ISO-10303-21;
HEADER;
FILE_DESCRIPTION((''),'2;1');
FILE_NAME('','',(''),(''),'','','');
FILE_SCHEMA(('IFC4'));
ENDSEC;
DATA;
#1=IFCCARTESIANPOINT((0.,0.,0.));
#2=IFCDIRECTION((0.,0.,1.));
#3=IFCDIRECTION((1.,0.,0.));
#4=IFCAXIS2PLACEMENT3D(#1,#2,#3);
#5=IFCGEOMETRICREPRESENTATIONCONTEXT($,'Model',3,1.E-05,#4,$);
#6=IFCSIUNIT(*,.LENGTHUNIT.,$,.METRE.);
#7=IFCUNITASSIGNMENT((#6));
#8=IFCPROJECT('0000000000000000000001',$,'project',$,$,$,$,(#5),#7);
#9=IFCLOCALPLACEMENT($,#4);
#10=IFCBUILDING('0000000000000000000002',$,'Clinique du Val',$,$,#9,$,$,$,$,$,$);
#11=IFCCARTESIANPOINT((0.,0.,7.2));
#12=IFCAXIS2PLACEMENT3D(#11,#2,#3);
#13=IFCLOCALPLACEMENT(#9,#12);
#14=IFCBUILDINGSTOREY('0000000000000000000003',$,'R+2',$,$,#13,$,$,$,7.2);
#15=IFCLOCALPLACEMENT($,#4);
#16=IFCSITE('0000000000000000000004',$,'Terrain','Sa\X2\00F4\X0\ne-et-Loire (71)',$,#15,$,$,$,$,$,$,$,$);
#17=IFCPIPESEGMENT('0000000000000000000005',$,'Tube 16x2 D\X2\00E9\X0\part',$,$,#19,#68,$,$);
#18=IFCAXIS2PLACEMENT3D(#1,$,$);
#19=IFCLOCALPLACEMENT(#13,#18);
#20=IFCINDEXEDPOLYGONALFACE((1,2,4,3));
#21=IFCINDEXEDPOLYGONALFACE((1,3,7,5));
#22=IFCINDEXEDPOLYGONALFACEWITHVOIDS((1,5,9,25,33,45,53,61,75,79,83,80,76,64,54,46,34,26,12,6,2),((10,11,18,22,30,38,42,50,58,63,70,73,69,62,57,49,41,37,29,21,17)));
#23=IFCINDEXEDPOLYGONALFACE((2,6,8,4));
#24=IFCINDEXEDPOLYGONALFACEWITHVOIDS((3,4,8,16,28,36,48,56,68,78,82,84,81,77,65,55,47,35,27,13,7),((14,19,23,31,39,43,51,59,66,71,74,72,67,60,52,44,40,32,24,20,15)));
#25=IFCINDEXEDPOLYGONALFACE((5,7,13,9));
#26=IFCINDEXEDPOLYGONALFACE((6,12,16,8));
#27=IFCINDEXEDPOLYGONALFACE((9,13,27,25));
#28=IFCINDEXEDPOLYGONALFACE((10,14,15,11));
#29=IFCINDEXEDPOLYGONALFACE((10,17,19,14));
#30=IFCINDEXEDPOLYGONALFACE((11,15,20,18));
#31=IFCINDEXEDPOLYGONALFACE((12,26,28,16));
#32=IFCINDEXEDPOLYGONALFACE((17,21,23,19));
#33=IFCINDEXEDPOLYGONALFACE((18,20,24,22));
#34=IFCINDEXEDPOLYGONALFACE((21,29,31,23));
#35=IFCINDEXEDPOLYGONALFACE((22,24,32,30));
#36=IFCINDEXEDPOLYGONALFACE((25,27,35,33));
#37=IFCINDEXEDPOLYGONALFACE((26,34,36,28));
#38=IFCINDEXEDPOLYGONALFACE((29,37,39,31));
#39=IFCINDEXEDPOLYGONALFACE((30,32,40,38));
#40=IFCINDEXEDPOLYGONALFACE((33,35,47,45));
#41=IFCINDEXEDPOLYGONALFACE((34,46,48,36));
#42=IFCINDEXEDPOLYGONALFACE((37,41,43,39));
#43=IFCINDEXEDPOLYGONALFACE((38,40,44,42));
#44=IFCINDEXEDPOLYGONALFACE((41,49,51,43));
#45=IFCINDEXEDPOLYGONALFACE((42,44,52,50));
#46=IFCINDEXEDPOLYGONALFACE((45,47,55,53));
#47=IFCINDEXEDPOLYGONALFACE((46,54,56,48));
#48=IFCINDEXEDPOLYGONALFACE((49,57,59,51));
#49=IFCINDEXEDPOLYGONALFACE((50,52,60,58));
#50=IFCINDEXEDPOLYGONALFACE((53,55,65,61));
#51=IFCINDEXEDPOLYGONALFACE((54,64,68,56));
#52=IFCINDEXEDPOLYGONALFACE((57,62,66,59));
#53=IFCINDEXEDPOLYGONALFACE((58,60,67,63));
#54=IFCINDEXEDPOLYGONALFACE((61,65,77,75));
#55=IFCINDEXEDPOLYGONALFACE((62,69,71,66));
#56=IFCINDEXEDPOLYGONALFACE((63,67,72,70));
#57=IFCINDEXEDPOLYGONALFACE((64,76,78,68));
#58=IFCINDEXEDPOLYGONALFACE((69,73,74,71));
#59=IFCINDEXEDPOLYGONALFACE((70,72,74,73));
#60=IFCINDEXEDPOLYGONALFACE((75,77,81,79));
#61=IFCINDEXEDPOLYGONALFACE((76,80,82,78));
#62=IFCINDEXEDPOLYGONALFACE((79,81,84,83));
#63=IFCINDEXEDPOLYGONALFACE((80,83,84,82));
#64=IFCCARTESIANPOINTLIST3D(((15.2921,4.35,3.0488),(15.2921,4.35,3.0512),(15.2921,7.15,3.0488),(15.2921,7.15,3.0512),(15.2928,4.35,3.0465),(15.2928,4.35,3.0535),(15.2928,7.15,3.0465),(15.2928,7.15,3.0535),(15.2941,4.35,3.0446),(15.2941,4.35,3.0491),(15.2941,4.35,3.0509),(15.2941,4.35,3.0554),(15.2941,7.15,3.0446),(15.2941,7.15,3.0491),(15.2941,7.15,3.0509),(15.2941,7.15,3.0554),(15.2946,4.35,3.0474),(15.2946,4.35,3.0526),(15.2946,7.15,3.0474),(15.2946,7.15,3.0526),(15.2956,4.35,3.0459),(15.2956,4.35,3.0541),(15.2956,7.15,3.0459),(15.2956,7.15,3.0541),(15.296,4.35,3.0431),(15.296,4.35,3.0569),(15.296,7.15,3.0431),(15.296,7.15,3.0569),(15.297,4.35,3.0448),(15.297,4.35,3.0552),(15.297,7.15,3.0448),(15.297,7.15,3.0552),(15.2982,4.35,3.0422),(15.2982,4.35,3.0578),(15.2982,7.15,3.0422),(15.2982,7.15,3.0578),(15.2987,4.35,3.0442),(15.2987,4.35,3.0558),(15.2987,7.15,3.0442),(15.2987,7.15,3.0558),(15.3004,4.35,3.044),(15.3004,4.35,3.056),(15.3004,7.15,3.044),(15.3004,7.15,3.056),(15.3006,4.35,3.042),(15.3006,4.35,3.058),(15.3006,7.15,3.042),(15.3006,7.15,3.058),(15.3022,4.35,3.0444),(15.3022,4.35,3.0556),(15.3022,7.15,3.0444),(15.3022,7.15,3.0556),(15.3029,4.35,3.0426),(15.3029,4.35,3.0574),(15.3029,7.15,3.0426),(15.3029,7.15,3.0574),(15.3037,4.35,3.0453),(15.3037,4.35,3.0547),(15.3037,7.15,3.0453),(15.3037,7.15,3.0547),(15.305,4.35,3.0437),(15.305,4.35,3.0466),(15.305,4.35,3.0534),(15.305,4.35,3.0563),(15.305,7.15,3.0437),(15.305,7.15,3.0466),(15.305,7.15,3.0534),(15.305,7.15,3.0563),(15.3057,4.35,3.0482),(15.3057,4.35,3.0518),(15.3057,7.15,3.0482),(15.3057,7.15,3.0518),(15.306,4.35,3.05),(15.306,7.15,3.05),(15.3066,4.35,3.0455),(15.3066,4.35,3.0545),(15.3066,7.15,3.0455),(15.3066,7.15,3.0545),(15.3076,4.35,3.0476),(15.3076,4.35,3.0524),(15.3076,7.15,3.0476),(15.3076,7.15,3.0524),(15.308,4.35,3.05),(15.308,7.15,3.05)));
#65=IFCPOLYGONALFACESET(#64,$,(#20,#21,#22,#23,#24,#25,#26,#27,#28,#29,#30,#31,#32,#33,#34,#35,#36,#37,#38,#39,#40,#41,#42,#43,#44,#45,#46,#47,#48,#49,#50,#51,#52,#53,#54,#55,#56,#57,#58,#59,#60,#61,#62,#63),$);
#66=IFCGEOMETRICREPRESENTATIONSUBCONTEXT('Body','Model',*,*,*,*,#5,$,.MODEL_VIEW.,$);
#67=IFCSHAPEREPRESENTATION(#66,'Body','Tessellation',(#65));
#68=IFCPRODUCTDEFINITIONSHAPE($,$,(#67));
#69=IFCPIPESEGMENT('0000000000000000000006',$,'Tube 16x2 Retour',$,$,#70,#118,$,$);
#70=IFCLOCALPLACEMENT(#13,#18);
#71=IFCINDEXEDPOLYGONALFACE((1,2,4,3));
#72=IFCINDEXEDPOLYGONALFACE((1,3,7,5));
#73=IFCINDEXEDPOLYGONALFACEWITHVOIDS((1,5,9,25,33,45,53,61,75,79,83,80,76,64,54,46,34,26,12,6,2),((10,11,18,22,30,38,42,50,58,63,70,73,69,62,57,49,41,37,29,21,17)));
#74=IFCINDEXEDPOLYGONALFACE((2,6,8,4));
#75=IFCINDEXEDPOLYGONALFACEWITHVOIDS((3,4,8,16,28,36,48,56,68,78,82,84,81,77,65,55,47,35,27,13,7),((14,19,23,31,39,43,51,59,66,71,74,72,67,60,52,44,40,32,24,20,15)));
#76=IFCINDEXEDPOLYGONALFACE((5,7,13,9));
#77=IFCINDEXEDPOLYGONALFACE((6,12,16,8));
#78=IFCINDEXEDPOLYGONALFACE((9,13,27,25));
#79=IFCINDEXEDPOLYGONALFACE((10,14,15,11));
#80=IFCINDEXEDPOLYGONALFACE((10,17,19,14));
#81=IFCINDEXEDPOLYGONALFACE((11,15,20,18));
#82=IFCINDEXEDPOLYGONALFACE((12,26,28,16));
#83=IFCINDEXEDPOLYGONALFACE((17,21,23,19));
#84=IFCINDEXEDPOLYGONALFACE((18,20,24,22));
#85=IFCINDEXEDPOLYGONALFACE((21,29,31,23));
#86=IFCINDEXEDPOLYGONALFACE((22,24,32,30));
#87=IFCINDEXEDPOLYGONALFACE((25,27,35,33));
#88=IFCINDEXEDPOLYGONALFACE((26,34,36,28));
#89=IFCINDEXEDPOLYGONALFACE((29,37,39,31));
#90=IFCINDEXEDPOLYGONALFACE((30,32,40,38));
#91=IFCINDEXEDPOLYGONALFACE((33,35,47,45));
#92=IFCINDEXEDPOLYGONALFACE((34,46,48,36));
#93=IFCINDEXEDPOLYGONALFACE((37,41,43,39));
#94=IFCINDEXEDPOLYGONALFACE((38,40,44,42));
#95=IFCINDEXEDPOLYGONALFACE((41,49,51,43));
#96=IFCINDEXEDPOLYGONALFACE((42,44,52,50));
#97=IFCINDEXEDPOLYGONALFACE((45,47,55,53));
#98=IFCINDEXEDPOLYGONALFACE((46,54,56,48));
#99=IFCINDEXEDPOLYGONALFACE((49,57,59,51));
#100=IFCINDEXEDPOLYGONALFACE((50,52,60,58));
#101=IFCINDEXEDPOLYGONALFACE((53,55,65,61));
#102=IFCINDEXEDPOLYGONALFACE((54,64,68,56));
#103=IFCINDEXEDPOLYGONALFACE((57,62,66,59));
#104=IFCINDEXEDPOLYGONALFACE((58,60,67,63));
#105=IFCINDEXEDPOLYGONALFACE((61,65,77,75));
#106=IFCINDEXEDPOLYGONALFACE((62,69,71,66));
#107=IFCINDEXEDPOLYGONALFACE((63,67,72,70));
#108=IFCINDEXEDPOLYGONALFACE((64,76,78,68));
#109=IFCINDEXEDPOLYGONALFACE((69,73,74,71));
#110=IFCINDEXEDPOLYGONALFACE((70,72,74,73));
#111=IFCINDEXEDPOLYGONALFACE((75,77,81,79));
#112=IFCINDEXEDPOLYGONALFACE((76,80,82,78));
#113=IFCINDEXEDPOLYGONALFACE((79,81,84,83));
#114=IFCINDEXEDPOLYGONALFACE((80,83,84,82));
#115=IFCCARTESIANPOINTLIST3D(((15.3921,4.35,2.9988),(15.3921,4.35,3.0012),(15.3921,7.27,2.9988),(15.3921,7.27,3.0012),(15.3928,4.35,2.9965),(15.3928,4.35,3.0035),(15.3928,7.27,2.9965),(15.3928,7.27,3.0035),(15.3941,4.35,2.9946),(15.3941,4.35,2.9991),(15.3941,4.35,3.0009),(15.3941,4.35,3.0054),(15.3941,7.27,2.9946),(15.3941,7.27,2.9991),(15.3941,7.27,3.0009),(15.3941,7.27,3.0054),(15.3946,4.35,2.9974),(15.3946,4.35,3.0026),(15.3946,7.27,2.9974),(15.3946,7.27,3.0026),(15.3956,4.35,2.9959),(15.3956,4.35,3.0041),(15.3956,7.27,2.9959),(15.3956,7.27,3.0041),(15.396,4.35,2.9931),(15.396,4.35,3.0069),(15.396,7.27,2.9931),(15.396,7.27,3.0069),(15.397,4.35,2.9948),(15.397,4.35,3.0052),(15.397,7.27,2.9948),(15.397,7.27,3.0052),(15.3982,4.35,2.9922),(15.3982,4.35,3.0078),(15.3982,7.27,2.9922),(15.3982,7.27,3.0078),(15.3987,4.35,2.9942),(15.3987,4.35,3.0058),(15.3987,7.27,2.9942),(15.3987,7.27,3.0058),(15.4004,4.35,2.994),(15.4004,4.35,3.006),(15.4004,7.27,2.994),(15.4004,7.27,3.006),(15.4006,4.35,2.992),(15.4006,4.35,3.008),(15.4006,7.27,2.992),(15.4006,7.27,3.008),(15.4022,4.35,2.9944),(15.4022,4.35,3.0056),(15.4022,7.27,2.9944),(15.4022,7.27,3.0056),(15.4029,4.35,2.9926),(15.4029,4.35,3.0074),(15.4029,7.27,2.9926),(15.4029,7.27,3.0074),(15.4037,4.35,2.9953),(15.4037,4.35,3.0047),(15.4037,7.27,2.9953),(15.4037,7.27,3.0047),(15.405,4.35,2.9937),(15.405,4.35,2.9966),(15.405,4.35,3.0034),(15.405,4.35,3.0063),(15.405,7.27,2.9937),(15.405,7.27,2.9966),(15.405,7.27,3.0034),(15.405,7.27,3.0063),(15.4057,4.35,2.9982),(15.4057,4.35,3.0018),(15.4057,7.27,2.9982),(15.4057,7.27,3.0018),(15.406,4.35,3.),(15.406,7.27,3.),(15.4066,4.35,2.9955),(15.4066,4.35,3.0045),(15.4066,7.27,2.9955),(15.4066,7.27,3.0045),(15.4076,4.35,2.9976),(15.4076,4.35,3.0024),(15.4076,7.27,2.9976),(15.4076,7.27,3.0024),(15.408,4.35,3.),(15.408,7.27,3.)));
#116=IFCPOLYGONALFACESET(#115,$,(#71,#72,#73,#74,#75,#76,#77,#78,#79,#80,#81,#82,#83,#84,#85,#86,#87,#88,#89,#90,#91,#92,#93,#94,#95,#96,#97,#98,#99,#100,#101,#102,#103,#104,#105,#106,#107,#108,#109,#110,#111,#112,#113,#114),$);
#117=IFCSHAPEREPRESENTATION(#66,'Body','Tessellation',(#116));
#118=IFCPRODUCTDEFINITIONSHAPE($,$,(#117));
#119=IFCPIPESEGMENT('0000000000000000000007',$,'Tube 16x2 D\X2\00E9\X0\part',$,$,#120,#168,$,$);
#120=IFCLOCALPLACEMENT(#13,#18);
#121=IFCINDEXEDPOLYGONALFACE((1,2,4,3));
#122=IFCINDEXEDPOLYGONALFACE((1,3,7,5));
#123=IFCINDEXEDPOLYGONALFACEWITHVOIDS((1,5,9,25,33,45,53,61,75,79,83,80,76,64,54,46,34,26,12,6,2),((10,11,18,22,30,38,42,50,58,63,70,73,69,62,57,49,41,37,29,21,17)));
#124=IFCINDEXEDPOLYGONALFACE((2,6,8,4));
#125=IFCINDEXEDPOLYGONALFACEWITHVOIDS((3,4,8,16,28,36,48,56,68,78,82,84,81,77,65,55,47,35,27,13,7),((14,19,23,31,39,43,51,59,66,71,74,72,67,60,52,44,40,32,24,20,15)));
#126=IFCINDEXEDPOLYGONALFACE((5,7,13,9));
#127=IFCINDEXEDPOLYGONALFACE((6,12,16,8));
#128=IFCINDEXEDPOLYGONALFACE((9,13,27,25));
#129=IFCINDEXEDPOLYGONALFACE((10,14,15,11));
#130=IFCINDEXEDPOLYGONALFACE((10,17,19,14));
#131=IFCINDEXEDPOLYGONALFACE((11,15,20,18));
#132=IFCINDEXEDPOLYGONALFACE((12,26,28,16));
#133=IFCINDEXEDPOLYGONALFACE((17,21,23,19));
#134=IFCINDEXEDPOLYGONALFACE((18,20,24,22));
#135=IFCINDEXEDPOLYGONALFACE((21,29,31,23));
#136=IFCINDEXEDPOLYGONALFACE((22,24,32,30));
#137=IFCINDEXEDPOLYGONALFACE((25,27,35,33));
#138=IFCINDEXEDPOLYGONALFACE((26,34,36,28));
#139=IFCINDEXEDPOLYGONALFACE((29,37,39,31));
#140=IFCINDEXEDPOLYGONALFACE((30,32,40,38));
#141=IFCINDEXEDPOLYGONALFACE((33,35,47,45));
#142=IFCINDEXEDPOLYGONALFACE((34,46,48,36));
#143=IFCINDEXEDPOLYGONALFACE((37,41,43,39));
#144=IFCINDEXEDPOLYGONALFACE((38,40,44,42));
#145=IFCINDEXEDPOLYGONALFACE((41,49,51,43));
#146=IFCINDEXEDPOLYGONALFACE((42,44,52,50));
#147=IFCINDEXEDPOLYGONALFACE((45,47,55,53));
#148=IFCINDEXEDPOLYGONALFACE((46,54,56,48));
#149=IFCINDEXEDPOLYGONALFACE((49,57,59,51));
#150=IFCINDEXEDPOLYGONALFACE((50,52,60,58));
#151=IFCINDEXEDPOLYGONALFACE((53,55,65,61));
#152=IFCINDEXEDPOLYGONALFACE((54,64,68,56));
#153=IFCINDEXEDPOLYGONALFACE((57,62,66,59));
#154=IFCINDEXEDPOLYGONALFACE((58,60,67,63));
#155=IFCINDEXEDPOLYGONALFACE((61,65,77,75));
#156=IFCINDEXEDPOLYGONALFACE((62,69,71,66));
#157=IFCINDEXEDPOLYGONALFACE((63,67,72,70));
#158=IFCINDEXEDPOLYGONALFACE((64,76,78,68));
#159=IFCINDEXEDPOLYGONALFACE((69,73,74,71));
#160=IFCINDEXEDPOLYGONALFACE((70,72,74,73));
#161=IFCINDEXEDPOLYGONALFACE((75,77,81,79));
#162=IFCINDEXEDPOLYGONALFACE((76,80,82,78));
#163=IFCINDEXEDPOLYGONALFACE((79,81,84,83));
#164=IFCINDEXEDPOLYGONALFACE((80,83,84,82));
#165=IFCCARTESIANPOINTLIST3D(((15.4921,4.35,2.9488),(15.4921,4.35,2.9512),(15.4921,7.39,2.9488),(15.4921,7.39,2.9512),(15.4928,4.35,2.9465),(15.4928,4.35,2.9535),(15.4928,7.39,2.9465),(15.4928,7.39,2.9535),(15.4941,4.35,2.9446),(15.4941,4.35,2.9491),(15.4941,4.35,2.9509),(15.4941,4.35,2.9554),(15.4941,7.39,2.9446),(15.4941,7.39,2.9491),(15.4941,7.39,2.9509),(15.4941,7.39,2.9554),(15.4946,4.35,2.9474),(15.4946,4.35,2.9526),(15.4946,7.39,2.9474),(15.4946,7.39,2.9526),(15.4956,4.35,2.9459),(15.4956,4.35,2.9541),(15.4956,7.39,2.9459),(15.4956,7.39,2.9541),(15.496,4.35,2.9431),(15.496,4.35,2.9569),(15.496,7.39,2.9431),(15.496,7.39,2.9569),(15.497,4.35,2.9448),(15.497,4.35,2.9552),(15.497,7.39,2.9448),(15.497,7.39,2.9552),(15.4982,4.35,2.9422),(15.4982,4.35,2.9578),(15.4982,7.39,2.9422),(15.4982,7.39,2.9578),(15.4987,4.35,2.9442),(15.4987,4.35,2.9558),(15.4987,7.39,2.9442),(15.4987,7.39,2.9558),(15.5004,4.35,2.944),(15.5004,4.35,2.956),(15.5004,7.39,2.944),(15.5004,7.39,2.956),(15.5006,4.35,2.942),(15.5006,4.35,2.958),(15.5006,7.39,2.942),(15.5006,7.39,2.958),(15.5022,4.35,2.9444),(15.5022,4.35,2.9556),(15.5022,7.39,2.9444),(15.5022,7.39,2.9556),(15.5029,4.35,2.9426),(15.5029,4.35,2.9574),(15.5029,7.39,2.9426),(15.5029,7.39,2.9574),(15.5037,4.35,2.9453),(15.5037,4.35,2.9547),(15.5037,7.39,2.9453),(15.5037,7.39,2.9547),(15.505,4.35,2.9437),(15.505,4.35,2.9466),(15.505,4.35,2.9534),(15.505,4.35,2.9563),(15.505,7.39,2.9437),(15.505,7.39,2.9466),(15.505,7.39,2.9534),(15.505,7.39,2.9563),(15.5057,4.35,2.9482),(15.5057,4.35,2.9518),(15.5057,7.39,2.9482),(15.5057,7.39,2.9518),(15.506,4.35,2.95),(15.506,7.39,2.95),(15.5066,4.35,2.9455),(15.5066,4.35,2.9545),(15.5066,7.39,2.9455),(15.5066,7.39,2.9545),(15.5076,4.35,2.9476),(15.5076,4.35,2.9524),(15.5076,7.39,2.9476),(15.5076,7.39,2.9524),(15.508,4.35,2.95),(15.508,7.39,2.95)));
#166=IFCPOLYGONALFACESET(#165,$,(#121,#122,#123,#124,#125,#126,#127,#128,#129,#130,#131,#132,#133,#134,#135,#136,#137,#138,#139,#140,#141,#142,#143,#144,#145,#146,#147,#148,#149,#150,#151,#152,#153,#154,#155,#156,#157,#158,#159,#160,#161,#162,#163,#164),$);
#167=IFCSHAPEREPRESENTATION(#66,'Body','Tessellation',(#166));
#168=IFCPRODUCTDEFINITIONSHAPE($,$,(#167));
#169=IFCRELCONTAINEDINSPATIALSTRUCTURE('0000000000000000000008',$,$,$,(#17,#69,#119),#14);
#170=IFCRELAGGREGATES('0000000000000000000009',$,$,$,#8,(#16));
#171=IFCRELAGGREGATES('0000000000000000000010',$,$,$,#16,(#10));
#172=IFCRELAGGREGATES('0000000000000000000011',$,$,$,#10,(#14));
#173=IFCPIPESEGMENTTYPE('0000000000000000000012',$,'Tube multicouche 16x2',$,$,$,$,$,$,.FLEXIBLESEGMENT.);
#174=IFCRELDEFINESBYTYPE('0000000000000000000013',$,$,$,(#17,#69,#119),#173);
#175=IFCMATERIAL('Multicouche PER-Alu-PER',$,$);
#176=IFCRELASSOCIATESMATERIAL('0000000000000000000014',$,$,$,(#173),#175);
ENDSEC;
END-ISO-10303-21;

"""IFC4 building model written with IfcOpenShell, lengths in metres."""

from ifc_helpers import new_model, si_unit, frame, origin_with_axes, place, context, subcontext, project, spatial, hollow_circle, extrude, material, type_object, element, save


model = new_model("IFC4")

# Units and contexts
model_context = context("Model", 3, precision=1e-05, world=origin_with_axes())
body_context = subcontext(model_context, "Body", "Model", "MODEL_VIEW")
ifc_project = project(units=[si_unit("LENGTHUNIT", "METRE")], contexts=[model_context])

# Site, building, storey
site_placement = place(None, origin_with_axes())
site = spatial("IfcSite", under=ifc_project, at=site_placement, Name="Terrain", Description="Saône-et-Loire (71)")
building_placement = place(None, origin_with_axes())
building = spatial("IfcBuilding", under=site, at=building_placement, Name="Clinique du Val")
storey_placement = place(building_placement, frame((0.0, 0.0, 7.2), z_axis=(0.0, 0.0, 1.0), x_axis=(1.0, 0.0, 0.0)))
storey = spatial("IfcBuildingStorey", under=building, at=storey_placement, Name="R+2", Elevation=7.2)

# Pipe segments
ifc_material_1 = material(Name="Multicouche PER-Alu-PER")
pipe_segment_type_1 = type_object("IfcPipeSegmentType", Name="Tube multicouche 16x2", PredefinedType="FLEXIBLESEGMENT", material=ifc_material_1)
pipe_segment_1_placement = place(storey_placement, frame((15.3, 7.15, 3.05), z_axis=(0.0, -1.0, 0.0), x_axis=(1.0, 0.0, 0.0)))
element("IfcPipeSegment", 1, at=pipe_segment_1_placement, inside=storey, type_object=pipe_segment_type_1, Name="Tube 16x2 Départ", context=body_context, shape_type="SweptSolid", body=[
    extrude(hollow_circle(Radius=0.008, WallThickness=0.002), origin_with_axes(), (0.0, 0.0, 1.0), 2.8),
])
pipe_segment_2_placement = place(storey_placement, frame((15.4, 7.27, 3.0), z_axis=(0.0, -1.0, 0.0), x_axis=(1.0, 0.0, 0.0)))
element("IfcPipeSegment", 2, at=pipe_segment_2_placement, inside=storey, type_object=pipe_segment_type_1, Name="Tube 16x2 Retour", context=body_context, shape_type="SweptSolid", body=[
    extrude(hollow_circle(Radius=0.008, WallThickness=0.002), origin_with_axes(), (0.0, 0.0, 1.0), 2.92),
])
pipe_segment_3_placement = place(storey_placement, frame((15.5, 7.39, 2.95), z_axis=(0.0, -1.0, 0.0), x_axis=(1.0, 0.0, 0.0)))
element("IfcPipeSegment", 3, at=pipe_segment_3_placement, inside=storey, type_object=pipe_segment_type_1, Name="Tube 16x2 Départ", context=body_context, shape_type="SweptSolid", body=[
    extrude(hollow_circle(Radius=0.008, WallThickness=0.002), origin_with_axes(), (0.0, 0.0, 1.0), 3.04),
])

save(model, "model.ifc")
